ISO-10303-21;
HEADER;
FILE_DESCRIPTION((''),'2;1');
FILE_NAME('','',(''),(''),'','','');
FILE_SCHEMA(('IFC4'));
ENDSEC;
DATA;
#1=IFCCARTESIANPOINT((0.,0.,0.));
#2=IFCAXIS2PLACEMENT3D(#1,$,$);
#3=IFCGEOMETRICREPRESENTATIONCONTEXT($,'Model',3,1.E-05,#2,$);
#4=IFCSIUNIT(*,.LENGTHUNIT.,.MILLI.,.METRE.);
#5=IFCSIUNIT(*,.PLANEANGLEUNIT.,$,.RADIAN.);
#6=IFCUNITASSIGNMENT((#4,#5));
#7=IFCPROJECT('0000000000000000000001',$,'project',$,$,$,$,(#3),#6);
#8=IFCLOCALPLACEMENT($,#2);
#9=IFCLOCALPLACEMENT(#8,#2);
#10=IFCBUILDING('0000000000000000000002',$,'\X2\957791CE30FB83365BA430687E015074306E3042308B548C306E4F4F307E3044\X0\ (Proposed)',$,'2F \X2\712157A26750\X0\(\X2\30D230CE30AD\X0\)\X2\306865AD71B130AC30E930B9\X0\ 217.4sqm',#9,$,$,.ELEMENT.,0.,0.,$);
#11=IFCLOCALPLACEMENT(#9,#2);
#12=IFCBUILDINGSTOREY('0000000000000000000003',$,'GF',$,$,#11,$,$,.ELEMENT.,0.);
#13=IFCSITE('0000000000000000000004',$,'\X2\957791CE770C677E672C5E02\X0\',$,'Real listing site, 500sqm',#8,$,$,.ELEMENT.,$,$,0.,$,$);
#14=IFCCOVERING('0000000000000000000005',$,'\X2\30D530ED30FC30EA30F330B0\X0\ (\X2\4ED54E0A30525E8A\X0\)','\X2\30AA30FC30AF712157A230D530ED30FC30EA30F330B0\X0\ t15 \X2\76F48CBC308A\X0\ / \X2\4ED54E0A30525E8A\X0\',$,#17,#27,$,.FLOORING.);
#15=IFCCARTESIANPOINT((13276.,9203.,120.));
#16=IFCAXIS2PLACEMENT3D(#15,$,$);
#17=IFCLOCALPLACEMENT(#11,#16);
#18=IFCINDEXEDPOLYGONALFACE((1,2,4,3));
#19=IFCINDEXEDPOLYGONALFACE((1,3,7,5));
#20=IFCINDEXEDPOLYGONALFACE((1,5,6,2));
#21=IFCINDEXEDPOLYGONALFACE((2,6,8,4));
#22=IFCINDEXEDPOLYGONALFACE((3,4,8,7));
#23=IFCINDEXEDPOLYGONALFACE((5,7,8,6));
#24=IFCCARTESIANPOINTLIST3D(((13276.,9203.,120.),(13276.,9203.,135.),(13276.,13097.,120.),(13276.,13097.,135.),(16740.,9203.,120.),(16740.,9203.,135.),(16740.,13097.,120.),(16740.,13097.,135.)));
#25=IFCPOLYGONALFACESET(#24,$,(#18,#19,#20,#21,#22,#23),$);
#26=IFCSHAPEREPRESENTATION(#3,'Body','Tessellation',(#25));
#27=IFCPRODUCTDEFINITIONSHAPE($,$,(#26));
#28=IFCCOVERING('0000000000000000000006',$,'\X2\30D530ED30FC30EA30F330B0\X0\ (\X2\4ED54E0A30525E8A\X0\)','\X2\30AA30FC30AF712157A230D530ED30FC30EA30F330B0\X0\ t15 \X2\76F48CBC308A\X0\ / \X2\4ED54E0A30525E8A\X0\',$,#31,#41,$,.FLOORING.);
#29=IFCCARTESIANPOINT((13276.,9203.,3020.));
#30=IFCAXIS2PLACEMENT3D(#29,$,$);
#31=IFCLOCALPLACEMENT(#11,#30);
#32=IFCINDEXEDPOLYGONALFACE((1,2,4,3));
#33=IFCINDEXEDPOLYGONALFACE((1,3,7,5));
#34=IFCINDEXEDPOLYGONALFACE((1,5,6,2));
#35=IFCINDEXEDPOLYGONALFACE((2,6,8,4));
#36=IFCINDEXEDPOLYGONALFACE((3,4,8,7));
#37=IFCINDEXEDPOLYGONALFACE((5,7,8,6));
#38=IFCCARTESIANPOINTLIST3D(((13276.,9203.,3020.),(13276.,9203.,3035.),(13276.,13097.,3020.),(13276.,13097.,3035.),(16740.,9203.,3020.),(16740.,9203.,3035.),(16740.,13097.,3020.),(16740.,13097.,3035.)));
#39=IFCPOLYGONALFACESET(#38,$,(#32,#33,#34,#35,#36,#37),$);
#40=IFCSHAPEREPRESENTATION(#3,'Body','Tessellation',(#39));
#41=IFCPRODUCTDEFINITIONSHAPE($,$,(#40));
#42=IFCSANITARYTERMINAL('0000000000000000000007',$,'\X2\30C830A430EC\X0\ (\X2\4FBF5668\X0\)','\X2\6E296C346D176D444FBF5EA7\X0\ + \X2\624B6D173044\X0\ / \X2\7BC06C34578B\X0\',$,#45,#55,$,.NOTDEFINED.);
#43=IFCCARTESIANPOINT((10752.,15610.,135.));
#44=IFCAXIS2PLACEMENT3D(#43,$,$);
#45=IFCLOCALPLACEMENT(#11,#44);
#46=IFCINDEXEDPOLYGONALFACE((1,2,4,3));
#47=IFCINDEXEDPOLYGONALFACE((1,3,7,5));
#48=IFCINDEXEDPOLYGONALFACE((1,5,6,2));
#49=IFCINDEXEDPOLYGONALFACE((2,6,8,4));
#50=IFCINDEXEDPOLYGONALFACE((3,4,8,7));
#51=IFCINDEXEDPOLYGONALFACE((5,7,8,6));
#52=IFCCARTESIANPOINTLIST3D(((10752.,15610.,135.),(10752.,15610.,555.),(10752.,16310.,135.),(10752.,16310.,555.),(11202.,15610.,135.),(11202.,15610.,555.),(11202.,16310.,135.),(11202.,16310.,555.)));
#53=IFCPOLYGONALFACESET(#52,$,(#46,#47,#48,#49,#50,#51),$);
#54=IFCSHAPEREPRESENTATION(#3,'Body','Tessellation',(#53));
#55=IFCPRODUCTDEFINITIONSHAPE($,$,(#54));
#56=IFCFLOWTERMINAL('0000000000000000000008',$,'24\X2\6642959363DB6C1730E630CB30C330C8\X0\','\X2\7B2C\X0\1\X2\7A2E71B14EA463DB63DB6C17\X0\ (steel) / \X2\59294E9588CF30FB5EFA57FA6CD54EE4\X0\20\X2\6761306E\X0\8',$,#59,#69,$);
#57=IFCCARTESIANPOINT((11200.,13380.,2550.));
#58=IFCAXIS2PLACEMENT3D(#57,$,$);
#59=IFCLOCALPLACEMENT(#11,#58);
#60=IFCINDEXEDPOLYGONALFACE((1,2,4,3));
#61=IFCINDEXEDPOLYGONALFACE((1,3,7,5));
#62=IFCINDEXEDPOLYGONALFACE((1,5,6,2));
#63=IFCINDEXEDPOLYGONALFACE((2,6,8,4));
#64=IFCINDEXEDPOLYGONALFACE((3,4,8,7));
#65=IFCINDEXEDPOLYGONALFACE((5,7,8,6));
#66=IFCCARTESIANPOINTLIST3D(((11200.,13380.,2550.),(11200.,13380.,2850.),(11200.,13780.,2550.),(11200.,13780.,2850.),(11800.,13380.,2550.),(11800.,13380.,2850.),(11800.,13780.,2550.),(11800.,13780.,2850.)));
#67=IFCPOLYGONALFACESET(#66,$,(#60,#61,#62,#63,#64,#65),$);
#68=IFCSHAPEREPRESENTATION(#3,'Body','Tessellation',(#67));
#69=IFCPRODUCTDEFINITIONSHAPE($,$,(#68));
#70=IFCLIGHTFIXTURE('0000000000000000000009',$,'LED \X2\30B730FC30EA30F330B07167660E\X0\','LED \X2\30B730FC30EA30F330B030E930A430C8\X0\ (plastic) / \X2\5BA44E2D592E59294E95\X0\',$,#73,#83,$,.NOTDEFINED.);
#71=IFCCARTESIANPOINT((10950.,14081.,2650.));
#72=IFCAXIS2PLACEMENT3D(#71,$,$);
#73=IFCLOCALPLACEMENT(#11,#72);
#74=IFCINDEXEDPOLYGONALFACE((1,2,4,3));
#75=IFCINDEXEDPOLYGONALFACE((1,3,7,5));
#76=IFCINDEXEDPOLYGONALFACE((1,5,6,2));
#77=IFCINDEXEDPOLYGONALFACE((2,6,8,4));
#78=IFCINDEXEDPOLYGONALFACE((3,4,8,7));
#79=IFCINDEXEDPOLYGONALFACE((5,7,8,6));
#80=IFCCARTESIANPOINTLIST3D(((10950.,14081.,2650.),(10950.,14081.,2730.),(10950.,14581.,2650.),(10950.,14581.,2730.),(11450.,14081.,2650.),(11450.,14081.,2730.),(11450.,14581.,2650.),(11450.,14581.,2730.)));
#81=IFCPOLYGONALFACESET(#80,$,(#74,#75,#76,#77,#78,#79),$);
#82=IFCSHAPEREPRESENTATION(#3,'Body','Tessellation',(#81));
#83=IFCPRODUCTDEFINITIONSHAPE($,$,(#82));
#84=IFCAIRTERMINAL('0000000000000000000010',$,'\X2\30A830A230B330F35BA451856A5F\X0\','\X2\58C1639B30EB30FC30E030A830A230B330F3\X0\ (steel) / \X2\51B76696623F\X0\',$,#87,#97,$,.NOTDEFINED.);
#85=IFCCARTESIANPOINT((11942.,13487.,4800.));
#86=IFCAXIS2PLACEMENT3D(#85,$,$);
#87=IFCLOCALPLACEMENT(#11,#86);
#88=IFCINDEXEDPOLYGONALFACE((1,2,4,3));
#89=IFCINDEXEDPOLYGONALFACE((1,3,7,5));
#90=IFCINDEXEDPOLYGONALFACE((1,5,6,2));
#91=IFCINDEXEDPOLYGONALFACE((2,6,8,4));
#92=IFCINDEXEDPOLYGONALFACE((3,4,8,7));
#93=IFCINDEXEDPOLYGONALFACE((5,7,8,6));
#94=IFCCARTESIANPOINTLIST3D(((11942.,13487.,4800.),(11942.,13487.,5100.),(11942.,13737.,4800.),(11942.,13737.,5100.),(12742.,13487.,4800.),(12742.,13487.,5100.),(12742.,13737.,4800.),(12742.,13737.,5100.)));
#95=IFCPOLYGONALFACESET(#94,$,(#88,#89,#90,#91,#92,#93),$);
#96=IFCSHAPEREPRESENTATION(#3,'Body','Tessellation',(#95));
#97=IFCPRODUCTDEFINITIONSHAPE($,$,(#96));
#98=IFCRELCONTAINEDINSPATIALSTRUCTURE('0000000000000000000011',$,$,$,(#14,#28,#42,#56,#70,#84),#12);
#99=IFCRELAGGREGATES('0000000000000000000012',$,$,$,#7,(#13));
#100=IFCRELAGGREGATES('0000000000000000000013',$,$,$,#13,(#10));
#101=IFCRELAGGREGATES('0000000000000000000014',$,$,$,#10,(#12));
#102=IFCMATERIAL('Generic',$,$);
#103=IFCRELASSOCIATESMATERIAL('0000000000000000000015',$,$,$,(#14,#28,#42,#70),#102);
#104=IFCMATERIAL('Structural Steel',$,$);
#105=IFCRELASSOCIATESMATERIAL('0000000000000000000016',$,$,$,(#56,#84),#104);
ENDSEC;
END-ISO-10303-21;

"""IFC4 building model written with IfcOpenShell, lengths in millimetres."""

from ifc_helpers import new_model, si_unit, frame, frame_2d, origin, place, context, project, spatial, rectangle, extrude, material, element, save


model = new_model("IFC4")

# Units and contexts
model_context = context("Model", 3, precision=1e-05, world=origin())
ifc_project = project(units=[si_unit("LENGTHUNIT", "METRE", prefix="MILLI"), si_unit("PLANEANGLEUNIT", "RADIAN")], contexts=[model_context])

# Site, building, storey
site_placement = place(None, origin())
site = spatial("IfcSite", under=ifc_project, at=site_placement, Name="長野県松本市", ObjectType="Real listing site, 500sqm", CompositionType="ELEMENT", RefElevation=0.0)
building_placement = place(site_placement, origin())
building = spatial("IfcBuilding", under=site, at=building_placement, Name="長野・茶室と縁側のある和の住まい (Proposed)", ObjectType="2F 無垢材(ヒノキ)と断熱ガラス 217.4sqm", CompositionType="ELEMENT", ElevationOfRefHeight=0.0, ElevationOfTerrain=0.0)
storey_placement = place(building_placement, origin())
storey = spatial("IfcBuildingStorey", under=building, at=storey_placement, Name="GF", CompositionType="ELEMENT", Elevation=0.0)

# Coverings
ifc_material_1 = material(Name="Generic")
covering_1_placement = place(storey_placement, frame((13276.0, 9203.0, 120.0)))
element("IfcCovering", 1, at=covering_1_placement, inside=storey, material=ifc_material_1, Name="フローリング (仕上げ床)", Description="オーク無垢フローリング t15 直貼り / 仕上げ床", PredefinedType="FLOORING", context=model_context, shape_type="SweptSolid", body=[
    extrude(rectangle(XDim=3464.0, YDim=3894.0, at=frame_2d((1732.0, 1947.0))), frame((13276.0, 9203.0, 120.0)), (0.0, 0.0, 1.0), 15.0),
])
covering_2_placement = place(storey_placement, frame((13276.0, 9203.0, 3020.0)))
element("IfcCovering", 2, at=covering_2_placement, inside=storey, material=ifc_material_1, Name="フローリング (仕上げ床)", Description="オーク無垢フローリング t15 直貼り / 仕上げ床", PredefinedType="FLOORING", context=model_context, shape_type="SweptSolid", body=[
    extrude(rectangle(XDim=3464.0, YDim=3894.0, at=frame_2d((1732.0, 1947.0))), frame((13276.0, 9203.0, 3020.0)), (0.0, 0.0, 1.0), 15.0),
])

# Sanitary terminal
sanitary_terminal_placement = place(storey_placement, frame((10752.0, 15610.0, 135.0)))
element("IfcSanitaryTerminal", 3, at=sanitary_terminal_placement, inside=storey, material=ifc_material_1, Name="トイレ (便器)", Description="温水洗浄便座 + 手洗い / 節水型", PredefinedType="NOTDEFINED", context=model_context, shape_type="SweptSolid", body=[
    extrude(rectangle(XDim=450.0, YDim=700.0, at=frame_2d((225.0, 350.0))), frame((10752.0, 15610.0, 135.0)), (0.0, 0.0, 1.0), 420.0),
])

# Flow terminal
ifc_material_2 = material(Name="Structural Steel")
flow_terminal_placement = place(storey_placement, frame((11200.0, 13380.0, 2550.0)))
element("IfcFlowTerminal", 4, at=flow_terminal_placement, inside=storey, material=ifc_material_2, Name="24時間換気ユニット", Description="第1種熱交換換気 (steel) / 天井裏・建基法令20条の8", context=model_context, shape_type="SweptSolid", body=[
    extrude(rectangle(XDim=600.0, YDim=400.0, at=frame_2d((300.0, 200.0))), frame((11200.0, 13380.0, 2550.0)), (0.0, 0.0, 1.0), 300.0),
])

# Light fixture
light_fixture_placement = place(storey_placement, frame((10950.0, 14081.0, 2650.0)))
element("IfcLightFixture", 5, at=light_fixture_placement, inside=storey, material=ifc_material_1, Name="LED シーリング照明", Description="LED シーリングライト (plastic) / 室中央天井", PredefinedType="NOTDEFINED", context=model_context, shape_type="SweptSolid", body=[
    extrude(rectangle(XDim=500.0, YDim=500.0, at=frame_2d((250.0, 250.0))), frame((10950.0, 14081.0, 2650.0)), (0.0, 0.0, 1.0), 80.0),
])

# Air terminal
air_terminal_placement = place(storey_placement, frame((11942.0, 13487.0, 4800.0)))
element("IfcAirTerminal", 6, at=air_terminal_placement, inside=storey, material=ifc_material_2, Name="エアコン室内機", Description="壁掛ルームエアコン (steel) / 冷暖房", PredefinedType="NOTDEFINED", context=model_context, shape_type="SweptSolid", body=[
    extrude(rectangle(XDim=800.0, YDim=250.0, at=frame_2d((400.0, 125.0))), frame((11942.0, 13487.0, 4800.0)), (0.0, 0.0, 1.0), 300.0),
])

save(model, "model.ifc")
